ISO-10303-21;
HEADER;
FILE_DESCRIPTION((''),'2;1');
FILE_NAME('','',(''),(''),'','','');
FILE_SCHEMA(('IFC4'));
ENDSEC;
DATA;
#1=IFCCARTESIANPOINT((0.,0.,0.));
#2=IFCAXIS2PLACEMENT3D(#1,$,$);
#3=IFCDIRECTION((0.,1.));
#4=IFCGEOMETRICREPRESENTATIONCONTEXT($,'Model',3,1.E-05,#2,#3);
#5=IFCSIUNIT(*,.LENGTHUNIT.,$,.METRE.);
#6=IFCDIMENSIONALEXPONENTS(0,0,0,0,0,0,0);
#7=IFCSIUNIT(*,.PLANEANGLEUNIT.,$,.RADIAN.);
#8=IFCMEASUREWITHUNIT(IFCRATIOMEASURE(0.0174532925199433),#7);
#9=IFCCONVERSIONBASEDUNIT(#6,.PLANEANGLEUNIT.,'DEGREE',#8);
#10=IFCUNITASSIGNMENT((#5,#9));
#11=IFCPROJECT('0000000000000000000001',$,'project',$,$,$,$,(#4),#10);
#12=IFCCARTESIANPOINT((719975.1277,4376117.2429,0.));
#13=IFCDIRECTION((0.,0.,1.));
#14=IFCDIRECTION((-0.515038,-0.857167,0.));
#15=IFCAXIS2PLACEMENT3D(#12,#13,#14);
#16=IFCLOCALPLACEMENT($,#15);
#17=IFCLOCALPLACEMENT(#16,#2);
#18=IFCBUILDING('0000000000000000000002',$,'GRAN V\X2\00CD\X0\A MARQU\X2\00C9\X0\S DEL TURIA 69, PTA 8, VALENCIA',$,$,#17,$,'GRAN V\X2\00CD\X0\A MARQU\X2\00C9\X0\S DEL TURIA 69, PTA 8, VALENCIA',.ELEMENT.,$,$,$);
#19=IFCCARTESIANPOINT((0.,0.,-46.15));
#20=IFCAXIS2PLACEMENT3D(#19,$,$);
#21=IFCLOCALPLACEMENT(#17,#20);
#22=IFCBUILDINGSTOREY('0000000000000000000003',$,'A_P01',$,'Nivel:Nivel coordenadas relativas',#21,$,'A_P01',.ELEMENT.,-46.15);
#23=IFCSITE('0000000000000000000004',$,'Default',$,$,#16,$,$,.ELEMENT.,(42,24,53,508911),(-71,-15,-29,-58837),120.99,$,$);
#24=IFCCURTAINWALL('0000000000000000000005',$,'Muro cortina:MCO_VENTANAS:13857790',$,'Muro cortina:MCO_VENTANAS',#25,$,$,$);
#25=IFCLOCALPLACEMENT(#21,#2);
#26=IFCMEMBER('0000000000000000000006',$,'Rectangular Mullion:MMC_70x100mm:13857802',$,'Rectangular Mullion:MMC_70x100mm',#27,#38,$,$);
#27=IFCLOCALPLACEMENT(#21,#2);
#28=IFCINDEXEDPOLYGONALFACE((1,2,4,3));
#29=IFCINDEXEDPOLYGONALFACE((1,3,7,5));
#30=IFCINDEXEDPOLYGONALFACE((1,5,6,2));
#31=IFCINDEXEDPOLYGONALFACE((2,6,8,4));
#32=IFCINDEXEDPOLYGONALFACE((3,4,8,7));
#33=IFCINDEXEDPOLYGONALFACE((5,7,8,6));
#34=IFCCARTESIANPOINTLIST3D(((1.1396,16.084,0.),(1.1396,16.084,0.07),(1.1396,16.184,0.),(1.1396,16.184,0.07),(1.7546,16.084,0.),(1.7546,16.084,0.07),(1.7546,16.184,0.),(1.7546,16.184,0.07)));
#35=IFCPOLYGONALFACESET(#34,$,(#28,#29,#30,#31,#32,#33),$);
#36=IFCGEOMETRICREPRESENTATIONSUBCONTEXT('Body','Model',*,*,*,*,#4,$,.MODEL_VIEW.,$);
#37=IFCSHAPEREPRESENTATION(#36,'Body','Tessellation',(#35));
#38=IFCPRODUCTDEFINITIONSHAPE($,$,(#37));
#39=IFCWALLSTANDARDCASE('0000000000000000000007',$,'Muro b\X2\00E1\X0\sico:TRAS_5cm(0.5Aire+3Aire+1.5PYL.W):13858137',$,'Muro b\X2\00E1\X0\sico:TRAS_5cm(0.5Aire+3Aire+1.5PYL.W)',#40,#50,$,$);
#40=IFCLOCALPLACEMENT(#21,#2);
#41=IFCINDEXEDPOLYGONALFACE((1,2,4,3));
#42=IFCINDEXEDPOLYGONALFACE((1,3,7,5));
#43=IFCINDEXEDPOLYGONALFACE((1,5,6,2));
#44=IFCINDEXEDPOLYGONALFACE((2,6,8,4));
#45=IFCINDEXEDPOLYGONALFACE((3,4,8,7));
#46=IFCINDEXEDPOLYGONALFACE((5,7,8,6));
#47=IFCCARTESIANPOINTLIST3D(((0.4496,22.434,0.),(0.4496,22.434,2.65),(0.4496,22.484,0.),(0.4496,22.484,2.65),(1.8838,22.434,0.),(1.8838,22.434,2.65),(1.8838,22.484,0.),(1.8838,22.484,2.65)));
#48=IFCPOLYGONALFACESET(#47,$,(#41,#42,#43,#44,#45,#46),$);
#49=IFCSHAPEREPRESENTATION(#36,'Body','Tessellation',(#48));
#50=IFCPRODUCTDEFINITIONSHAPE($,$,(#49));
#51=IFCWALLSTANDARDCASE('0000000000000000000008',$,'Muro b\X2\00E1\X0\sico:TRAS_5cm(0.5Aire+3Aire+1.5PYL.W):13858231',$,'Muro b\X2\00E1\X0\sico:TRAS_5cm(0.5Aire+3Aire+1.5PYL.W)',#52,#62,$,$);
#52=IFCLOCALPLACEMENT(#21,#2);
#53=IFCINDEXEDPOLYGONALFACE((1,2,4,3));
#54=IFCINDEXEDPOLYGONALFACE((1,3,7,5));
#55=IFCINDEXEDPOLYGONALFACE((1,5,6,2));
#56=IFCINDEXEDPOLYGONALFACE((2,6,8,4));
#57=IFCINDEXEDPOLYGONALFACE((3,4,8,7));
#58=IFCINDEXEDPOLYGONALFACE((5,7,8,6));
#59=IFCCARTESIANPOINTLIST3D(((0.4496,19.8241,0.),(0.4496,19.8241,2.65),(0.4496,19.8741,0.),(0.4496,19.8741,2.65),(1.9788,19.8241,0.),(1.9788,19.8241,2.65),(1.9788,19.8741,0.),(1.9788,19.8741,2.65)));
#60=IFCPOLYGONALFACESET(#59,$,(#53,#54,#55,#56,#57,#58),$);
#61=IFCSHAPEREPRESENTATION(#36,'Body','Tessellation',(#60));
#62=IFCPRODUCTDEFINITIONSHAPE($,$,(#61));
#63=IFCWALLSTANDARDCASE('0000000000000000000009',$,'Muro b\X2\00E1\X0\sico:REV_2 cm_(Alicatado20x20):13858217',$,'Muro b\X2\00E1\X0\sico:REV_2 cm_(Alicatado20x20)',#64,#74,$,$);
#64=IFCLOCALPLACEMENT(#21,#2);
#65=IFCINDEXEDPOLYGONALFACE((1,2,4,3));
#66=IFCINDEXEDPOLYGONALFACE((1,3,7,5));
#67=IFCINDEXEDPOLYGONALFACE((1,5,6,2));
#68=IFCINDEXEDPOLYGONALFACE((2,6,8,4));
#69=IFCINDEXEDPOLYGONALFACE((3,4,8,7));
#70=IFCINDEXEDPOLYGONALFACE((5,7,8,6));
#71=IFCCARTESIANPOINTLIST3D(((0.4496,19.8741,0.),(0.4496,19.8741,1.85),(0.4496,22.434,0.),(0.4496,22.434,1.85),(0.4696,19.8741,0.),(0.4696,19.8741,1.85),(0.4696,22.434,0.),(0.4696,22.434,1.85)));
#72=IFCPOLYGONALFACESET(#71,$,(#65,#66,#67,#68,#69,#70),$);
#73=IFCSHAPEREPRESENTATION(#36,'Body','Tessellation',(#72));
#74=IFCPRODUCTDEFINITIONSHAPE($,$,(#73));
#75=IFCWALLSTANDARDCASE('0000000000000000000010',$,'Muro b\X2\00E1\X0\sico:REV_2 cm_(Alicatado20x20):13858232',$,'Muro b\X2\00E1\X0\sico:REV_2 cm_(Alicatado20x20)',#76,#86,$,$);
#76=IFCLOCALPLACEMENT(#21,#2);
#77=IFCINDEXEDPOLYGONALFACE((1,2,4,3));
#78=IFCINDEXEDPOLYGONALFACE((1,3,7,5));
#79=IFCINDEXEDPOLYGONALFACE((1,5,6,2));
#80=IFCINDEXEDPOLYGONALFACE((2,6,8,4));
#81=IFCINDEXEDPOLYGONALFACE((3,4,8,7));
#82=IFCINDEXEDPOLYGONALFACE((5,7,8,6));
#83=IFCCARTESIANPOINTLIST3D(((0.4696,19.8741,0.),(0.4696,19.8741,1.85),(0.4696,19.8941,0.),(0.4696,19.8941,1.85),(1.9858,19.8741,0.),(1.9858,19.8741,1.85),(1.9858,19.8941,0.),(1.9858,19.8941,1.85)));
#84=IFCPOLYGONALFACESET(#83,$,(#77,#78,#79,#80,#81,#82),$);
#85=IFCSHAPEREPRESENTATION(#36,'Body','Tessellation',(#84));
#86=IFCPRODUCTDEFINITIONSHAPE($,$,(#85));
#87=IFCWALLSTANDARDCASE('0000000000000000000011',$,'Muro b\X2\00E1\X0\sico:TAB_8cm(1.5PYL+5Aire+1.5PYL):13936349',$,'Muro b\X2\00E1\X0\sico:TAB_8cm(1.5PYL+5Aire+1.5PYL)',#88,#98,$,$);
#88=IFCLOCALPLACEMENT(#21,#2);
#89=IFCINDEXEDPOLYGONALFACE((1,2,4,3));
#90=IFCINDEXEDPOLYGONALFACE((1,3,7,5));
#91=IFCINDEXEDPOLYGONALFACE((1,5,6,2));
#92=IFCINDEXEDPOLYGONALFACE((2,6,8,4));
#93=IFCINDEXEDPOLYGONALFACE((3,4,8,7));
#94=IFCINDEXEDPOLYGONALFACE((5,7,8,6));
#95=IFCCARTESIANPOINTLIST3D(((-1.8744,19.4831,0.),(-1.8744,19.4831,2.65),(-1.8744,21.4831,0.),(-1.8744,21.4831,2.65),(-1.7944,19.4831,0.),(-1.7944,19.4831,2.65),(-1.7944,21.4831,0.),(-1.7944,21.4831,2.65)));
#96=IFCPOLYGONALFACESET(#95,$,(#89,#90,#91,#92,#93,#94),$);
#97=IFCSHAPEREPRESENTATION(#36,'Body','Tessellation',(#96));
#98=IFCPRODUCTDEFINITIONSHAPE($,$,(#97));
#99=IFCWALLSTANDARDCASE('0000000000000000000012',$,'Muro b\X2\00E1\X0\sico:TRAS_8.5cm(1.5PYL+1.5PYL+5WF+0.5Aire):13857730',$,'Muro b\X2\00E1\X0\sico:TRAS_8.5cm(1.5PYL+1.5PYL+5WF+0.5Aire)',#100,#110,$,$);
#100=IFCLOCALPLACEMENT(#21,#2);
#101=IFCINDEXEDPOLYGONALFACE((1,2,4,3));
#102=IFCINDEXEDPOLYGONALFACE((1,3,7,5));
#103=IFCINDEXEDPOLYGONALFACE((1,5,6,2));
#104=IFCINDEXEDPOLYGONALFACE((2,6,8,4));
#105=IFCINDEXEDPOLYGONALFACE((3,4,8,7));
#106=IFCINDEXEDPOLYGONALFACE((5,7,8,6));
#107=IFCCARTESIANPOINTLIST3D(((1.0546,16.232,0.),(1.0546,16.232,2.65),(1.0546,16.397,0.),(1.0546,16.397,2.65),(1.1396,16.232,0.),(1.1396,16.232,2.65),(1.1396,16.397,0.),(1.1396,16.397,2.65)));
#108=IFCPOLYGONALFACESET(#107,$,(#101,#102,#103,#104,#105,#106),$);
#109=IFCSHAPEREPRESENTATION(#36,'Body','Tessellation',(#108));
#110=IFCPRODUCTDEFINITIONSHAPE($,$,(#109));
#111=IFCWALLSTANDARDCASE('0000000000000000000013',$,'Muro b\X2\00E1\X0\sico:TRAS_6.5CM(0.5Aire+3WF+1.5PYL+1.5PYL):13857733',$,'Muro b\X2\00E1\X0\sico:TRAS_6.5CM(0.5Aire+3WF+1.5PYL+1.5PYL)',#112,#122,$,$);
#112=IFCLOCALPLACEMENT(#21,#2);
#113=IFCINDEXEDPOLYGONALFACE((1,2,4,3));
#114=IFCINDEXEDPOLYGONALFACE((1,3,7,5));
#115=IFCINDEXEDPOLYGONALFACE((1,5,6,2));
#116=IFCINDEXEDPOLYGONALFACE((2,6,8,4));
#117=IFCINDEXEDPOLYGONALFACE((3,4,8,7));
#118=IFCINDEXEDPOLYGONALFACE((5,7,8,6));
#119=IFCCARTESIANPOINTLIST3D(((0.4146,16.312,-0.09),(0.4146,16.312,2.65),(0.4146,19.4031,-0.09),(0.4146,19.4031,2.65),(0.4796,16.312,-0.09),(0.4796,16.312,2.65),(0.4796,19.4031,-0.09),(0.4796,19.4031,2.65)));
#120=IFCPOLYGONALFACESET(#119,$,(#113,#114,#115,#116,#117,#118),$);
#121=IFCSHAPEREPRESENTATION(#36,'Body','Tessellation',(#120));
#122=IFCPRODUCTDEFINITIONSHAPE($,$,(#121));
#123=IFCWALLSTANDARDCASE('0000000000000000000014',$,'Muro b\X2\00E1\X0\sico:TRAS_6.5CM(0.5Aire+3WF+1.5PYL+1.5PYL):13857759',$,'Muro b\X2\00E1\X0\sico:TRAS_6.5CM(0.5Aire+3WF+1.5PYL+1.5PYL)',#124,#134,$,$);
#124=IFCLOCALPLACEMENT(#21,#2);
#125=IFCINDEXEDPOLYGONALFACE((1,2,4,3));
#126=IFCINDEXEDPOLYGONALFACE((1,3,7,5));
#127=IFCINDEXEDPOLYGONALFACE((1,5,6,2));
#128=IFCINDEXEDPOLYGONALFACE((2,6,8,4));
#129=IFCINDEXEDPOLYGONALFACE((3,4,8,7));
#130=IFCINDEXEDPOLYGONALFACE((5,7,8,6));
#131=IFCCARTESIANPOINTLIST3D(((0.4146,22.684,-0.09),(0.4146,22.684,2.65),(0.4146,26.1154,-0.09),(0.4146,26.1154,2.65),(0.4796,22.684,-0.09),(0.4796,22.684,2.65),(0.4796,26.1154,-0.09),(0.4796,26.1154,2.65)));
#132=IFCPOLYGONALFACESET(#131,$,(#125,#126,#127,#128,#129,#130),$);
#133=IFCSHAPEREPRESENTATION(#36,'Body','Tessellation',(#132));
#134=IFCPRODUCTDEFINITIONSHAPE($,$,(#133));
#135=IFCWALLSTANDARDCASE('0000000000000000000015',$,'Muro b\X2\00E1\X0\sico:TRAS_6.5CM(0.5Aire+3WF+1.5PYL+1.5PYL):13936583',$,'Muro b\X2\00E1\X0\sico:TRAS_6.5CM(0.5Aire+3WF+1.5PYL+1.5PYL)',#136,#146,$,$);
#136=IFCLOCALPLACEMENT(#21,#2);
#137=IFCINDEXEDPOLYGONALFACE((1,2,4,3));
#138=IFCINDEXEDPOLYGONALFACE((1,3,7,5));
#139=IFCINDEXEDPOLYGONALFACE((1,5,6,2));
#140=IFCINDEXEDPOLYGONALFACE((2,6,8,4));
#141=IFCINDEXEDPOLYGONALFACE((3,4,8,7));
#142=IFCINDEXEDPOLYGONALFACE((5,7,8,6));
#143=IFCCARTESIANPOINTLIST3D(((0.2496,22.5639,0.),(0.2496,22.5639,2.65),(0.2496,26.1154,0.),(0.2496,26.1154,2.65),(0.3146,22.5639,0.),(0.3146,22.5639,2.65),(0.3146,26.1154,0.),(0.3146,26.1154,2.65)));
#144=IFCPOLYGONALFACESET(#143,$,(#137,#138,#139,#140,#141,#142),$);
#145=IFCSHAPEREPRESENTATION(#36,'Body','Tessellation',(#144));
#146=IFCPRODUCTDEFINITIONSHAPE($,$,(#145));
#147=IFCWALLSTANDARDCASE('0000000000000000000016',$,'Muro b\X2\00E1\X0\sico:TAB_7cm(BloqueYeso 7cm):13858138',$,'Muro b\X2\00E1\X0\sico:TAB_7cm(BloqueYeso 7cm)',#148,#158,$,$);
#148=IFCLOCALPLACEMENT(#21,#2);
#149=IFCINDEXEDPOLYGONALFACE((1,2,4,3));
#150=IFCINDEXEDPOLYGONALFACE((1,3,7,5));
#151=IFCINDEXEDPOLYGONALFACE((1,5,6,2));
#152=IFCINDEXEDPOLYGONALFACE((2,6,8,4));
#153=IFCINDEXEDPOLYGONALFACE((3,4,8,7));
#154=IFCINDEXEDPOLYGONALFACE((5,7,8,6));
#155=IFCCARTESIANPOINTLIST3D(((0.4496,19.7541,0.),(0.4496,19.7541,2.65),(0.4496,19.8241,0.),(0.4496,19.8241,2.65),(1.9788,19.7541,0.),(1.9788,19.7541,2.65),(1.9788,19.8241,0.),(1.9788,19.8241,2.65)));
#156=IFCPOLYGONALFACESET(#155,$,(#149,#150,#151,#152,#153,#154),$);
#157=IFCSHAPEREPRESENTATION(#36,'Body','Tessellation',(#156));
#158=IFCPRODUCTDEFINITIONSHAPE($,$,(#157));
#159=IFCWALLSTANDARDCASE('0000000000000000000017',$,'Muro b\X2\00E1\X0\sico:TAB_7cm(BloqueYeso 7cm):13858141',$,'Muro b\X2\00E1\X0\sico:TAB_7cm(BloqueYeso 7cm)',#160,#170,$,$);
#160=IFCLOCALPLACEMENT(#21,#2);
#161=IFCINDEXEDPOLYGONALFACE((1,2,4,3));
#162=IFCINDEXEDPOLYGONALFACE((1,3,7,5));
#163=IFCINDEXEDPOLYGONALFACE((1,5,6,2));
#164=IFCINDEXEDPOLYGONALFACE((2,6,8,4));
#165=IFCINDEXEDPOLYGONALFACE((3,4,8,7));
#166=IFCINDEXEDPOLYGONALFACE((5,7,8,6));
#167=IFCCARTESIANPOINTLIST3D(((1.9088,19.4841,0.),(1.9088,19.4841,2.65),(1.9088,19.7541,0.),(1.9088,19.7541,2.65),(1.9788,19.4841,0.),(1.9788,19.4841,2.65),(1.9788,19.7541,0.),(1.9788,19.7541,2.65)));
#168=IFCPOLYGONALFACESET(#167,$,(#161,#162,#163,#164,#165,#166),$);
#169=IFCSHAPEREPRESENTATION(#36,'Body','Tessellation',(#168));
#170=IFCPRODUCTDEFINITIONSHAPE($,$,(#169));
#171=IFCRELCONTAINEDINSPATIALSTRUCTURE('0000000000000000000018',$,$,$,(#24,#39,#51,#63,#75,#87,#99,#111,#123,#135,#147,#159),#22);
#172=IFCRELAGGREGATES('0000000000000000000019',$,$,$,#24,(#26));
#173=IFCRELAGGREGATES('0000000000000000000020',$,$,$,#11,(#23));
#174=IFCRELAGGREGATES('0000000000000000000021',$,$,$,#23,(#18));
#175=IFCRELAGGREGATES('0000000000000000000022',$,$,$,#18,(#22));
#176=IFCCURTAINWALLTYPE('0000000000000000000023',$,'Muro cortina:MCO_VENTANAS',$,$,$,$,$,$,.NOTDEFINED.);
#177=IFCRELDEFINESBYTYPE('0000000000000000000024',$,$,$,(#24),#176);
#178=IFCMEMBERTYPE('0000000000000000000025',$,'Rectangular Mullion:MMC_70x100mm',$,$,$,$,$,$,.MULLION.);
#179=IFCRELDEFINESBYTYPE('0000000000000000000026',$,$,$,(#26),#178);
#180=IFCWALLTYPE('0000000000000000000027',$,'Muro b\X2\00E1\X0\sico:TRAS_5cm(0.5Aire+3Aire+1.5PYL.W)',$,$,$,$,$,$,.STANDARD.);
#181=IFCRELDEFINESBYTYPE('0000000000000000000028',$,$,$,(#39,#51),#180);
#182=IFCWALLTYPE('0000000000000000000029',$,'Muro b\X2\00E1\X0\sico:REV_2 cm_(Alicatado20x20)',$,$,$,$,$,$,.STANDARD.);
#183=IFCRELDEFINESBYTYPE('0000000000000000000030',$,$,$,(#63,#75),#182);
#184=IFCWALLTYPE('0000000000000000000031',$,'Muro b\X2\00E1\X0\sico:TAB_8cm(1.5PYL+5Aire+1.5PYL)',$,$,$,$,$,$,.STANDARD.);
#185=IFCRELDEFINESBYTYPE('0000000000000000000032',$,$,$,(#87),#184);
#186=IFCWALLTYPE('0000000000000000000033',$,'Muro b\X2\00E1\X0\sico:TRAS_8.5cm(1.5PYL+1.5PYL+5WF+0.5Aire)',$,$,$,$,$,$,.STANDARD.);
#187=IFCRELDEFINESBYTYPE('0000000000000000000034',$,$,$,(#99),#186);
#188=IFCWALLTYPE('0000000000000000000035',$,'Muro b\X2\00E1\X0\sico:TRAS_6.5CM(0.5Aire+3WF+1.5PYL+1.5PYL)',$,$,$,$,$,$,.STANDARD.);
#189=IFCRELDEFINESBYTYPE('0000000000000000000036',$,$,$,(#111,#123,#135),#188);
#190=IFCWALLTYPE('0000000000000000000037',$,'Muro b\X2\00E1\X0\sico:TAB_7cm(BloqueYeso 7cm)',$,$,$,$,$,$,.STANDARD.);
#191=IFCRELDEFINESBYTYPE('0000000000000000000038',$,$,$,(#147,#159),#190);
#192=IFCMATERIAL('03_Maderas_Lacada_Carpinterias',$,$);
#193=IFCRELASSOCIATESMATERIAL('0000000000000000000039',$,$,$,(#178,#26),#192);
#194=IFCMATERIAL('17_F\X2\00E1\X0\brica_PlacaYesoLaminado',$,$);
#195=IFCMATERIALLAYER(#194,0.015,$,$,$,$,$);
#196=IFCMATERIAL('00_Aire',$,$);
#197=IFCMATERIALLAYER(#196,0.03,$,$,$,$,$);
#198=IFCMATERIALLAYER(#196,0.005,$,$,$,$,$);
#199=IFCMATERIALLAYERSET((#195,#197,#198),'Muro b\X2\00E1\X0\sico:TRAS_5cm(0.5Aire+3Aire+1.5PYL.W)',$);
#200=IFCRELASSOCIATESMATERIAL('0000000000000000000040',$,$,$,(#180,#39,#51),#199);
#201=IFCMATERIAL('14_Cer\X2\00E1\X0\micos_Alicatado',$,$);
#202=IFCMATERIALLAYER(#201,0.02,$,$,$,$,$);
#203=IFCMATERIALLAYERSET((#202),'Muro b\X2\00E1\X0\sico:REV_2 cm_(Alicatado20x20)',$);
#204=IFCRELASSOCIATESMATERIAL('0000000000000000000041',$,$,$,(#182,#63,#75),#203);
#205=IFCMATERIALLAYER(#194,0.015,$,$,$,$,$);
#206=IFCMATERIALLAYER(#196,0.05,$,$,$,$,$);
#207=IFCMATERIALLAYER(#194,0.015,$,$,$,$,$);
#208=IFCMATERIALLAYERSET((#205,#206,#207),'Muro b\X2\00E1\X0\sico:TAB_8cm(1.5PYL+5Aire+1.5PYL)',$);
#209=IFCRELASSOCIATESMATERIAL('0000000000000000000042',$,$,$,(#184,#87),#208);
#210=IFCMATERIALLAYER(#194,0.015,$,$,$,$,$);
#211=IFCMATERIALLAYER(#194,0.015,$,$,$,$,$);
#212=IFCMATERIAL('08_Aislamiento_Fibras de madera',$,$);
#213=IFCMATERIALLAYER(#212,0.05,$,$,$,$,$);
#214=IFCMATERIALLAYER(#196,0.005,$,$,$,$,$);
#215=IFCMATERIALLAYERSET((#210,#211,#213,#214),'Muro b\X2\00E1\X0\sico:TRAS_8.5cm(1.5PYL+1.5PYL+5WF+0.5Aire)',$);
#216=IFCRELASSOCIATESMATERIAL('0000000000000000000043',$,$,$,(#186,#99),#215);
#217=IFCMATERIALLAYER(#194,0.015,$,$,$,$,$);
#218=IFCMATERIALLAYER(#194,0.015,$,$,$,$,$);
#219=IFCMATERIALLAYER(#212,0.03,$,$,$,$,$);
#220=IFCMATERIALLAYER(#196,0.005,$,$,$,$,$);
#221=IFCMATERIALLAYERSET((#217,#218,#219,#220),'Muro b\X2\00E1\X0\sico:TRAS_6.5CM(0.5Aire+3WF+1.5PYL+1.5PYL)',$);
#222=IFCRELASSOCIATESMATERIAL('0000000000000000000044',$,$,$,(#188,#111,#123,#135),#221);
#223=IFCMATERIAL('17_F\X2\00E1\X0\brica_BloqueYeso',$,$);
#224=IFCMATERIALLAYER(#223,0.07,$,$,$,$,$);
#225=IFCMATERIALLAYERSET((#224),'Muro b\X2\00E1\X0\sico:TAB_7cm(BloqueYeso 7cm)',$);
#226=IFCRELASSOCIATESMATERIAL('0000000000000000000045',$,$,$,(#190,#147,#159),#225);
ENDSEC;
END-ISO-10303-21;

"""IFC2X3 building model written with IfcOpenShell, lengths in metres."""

from ifc_helpers import new_model, entity, si_unit, converted_unit, direction, frame, frame_2d, origin, origin_2d_with_axis, place, context, subcontext, project, spatial, rectangle, extrude, source, transform, mapped, material, layer, layer_set, layer_usage, type_object, type_shapes, element, aggregate, save


model = new_model("IFC2X3")

# Units and contexts
model_context = context("Model", 3, precision=1e-05, world=origin(), true_north=direction((0.0, 1.0)))
body_context = subcontext(model_context, "Body", "Model", "MODEL_VIEW")
ifc_project = project(units=[si_unit("LENGTHUNIT", "METRE"), converted_unit("PLANEANGLEUNIT", "DEGREE", entity("IfcRatioMeasure", 0.0174532925199433), si_unit("PLANEANGLEUNIT", "RADIAN"), dimensions=[0, 0, 0, 0, 0, 0, 0])], contexts=[model_context])

# Site, building, storey
site_placement = place(None, frame((719975.1277, 4376117.2429, 0.0), z_axis=(0.0, 0.0, 1.0), x_axis=(-0.515038, -0.857167, 0.0)))
site = spatial("IfcSite", under=ifc_project, at=site_placement, Name="Default", CompositionType="ELEMENT", RefLatitude=(42, 24, 53, 508911), RefLongitude=(-71, -15, -29, -58837), RefElevation=120.99)
building_placement = place(site_placement, origin())
building = spatial("IfcBuilding", under=site, at=building_placement, Name="GRAN VÍA MARQUÉS DEL TURIA 69, PTA 8, VALENCIA", LongName="GRAN VÍA MARQUÉS DEL TURIA 69, PTA 8, VALENCIA", CompositionType="ELEMENT")
storey_placement = place(building_placement, frame((0.0, 0.0, -46.15)))
storey = spatial("IfcBuildingStorey", under=building, at=storey_placement, Name="A_P01", ObjectType="Nivel:Nivel coordenadas relativas", LongName="A_P01", CompositionType="ELEMENT", Elevation=-46.15)

# Curtain wall, member
curtain_wall_type = type_object("IfcCurtainWallType", Name="Muro cortina:MCO_VENTANAS", PredefinedType="NOTDEFINED")
curtain_wall_placement = place(storey_placement, frame((0.0, 0.0, 46.15)))
curtain_wall = element("IfcCurtainWall", 1, at=curtain_wall_placement, inside=storey, type_object=curtain_wall_type, Name="Muro cortina:MCO_VENTANAS:13857790", ObjectType="Muro cortina:MCO_VENTANAS")
ifc_material_1 = material(Name="03_Maderas_Lacada_Carpinterias")
member_type = type_object("IfcMemberType", Name="Rectangular Mullion:MMC_70x100mm", PredefinedType="MULLION", material=ifc_material_1)
shared_shape_1 = source(origin(), body_context, "Body", "SweptSolid", [
    extrude(rectangle(XDim=0.1, YDim=0.07, at=origin_2d_with_axis()), frame((-0.035, 0.0, -0.615), z_axis=(0.0, 0.0, 1.0), x_axis=(0.0, -1.0, 0.0)), (0.0, 0.0, 1.0), 0.615),
])
type_shapes(member_type, [shared_shape_1])
member_placement = place(storey_placement, frame((1.1396, 16.134, 0.0), z_axis=(-1.0, 0.0, 0.0), x_axis=(0.0, 0.0, -1.0)))
member = element("IfcMember", 2, at=member_placement, type_object=member_type, material=ifc_material_1, Name="Rectangular Mullion:MMC_70x100mm:13857802", ObjectType="Rectangular Mullion:MMC_70x100mm", context=body_context, shape_type="MappedRepresentation", body=[
    mapped(shared_shape_1, transform((0.0, 0.0, 0.0), scale=1.0)),
])
aggregate(curtain_wall, [member])

# Walls
ifc_material_2 = material(Name="17_Fábrica_PlacaYesoLaminado")
ifc_layer_1 = layer(ifc_material_2, 0.015)
ifc_material_3 = material(Name="00_Aire")
ifc_layer_2 = layer(ifc_material_3, 0.03)
ifc_layer_3 = layer(ifc_material_3, 0.005)
ifc_layer_set_1 = layer_set([ifc_layer_1, ifc_layer_2, ifc_layer_3], Name="Muro básico:TRAS_5cm(0.5Aire+3Aire+1.5PYL.W)")
ifc_layer_usage_1 = layer_usage(ifc_layer_set_1, "AXIS2", "POSITIVE", -0.025)
wall_type_1 = type_object("IfcWallType", Name="Muro básico:TRAS_5cm(0.5Aire+3Aire+1.5PYL.W)", PredefinedType="STANDARD", material=ifc_layer_set_1)
wall_1_placement = place(storey_placement, frame((0.4496, 22.459, 0.0)))
element("IfcWallStandardCase", 3, at=wall_1_placement, inside=storey, type_object=wall_type_1, material=ifc_layer_usage_1, Name="Muro básico:TRAS_5cm(0.5Aire+3Aire+1.5PYL.W):13858137", ObjectType="Muro básico:TRAS_5cm(0.5Aire+3Aire+1.5PYL.W)", context=body_context, shape_type="SweptSolid", body=[
    extrude(rectangle(XDim=1.4342, YDim=0.05, at=frame_2d((0.7171, 0.0), x_axis=(-1.0, 0.0))), origin(), (0.0, 0.0, 1.0), 2.65),
])
ifc_layer_usage_2 = layer_usage(ifc_layer_set_1, "AXIS2", "NEGATIVE", 0.025)
wall_2_placement = place(storey_placement, frame((0.4496, 19.8491, 0.0)))
element("IfcWallStandardCase", 4, at=wall_2_placement, inside=storey, type_object=wall_type_1, material=ifc_layer_usage_2, Name="Muro básico:TRAS_5cm(0.5Aire+3Aire+1.5PYL.W):13858231", ObjectType="Muro básico:TRAS_5cm(0.5Aire+3Aire+1.5PYL.W)", context=body_context, shape_type="SweptSolid", body=[
    extrude(rectangle(XDim=1.5292, YDim=0.05, at=frame_2d((0.7646, 0.0), x_axis=(-1.0, 0.0))), origin(), (0.0, 0.0, 1.0), 2.65),
])
ifc_material_4 = material(Name="14_Cerámicos_Alicatado")
ifc_layer_4 = layer(ifc_material_4, 0.02)
ifc_layer_set_2 = layer_set([ifc_layer_4], Name="Muro básico:REV_2 cm_(Alicatado20x20)")
ifc_layer_usage_3 = layer_usage(ifc_layer_set_2, "AXIS2", "NEGATIVE", 0.01)
wall_type_2 = type_object("IfcWallType", Name="Muro básico:REV_2 cm_(Alicatado20x20)", PredefinedType="STANDARD", material=ifc_layer_set_2)
wall_3_placement = place(storey_placement, frame((0.4596, 22.434, 0.0), z_axis=(0.0, 0.0, 1.0), x_axis=(0.0, -1.0, 0.0)))
element("IfcWallStandardCase", 5, at=wall_3_placement, inside=storey, type_object=wall_type_2, material=ifc_layer_usage_3, Name="Muro básico:REV_2 cm_(Alicatado20x20):13858217", ObjectType="Muro básico:REV_2 cm_(Alicatado20x20)", context=body_context, shape_type="SweptSolid", body=[
    extrude(rectangle(XDim=2.56, YDim=0.02, at=frame_2d((1.28, 0.0), x_axis=(-1.0, 0.0))), origin(), (0.0, 0.0, 1.0), 1.85),
])
ifc_layer_usage_4 = layer_usage(ifc_layer_set_2, "AXIS2", "POSITIVE", -0.01)
wall_4_placement = place(storey_placement, frame((1.9858, 19.8841, 0.0), z_axis=(0.0, 0.0, 1.0), x_axis=(-1.0, 0.0, 0.0)))
element("IfcWallStandardCase", 6, at=wall_4_placement, inside=storey, type_object=wall_type_2, material=ifc_layer_usage_4, Name="Muro básico:REV_2 cm_(Alicatado20x20):13858232", ObjectType="Muro básico:REV_2 cm_(Alicatado20x20)", context=body_context, shape_type="SweptSolid", body=[
    extrude(rectangle(XDim=1.5162, YDim=0.02, at=frame_2d((0.7581, 0.0), x_axis=(-1.0, 0.0))), origin(), (0.0, 0.0, 1.0), 1.85),
])
ifc_layer_5 = layer(ifc_material_2, 0.015)
ifc_layer_6 = layer(ifc_material_3, 0.05)
ifc_layer_7 = layer(ifc_material_2, 0.015)
ifc_layer_set_3 = layer_set([ifc_layer_5, ifc_layer_6, ifc_layer_7], Name="Muro básico:TAB_8cm(1.5PYL+5Aire+1.5PYL)")
ifc_layer_usage_5 = layer_usage(ifc_layer_set_3, "AXIS2", "NEGATIVE", 0.04)
wall_type_3 = type_object("IfcWallType", Name="Muro básico:TAB_8cm(1.5PYL+5Aire+1.5PYL)", PredefinedType="STANDARD", material=ifc_layer_set_3)
wall_5_placement = place(storey_placement, frame((-1.8344, 21.4831, 0.0), z_axis=(0.0, 0.0, 1.0), x_axis=(0.0, -1.0, 0.0)))
element("IfcWallStandardCase", 7, at=wall_5_placement, inside=storey, type_object=wall_type_3, material=ifc_layer_usage_5, Name="Muro básico:TAB_8cm(1.5PYL+5Aire+1.5PYL):13936349", ObjectType="Muro básico:TAB_8cm(1.5PYL+5Aire+1.5PYL)", context=body_context, shape_type="SweptSolid", body=[
    extrude(rectangle(XDim=2.0, YDim=0.08, at=frame_2d((1.0, 0.0), x_axis=(-1.0, 0.0))), origin(), (0.0, 0.0, 1.0), 2.65),
])
ifc_layer_8 = layer(ifc_material_2, 0.015)
ifc_layer_9 = layer(ifc_material_2, 0.015)
ifc_material_5 = material(Name="08_Aislamiento_Fibras de madera")
ifc_layer_10 = layer(ifc_material_5, 0.05)
ifc_layer_11 = layer(ifc_material_3, 0.005)
ifc_layer_set_4 = layer_set([ifc_layer_8, ifc_layer_9, ifc_layer_10, ifc_layer_11], Name="Muro básico:TRAS_8.5cm(1.5PYL+1.5PYL+5WF+0.5Aire)")
ifc_layer_usage_6 = layer_usage(ifc_layer_set_4, "AXIS2", "NEGATIVE", 0.0425)
wall_type_4 = type_object("IfcWallType", Name="Muro básico:TRAS_8.5cm(1.5PYL+1.5PYL+5WF+0.5Aire)", PredefinedType="STANDARD", material=ifc_layer_set_4)
wall_6_placement = place(storey_placement, frame((1.0971, 16.397, 0.0), z_axis=(0.0, 0.0, 1.0), x_axis=(0.0, -1.0, 0.0)))
element("IfcWallStandardCase", 8, at=wall_6_placement, inside=storey, type_object=wall_type_4, material=ifc_layer_usage_6, Name="Muro básico:TRAS_8.5cm(1.5PYL+1.5PYL+5WF+0.5Aire):13857730", ObjectType="Muro básico:TRAS_8.5cm(1.5PYL+1.5PYL+5WF+0.5Aire)", context=body_context, shape_type="SweptSolid", body=[
    extrude(rectangle(XDim=0.165, YDim=0.085, at=frame_2d((0.0825, 0.0), x_axis=(-1.0, 0.0))), origin(), (0.0, 0.0, 1.0), 2.65),
])
ifc_layer_12 = layer(ifc_material_2, 0.015)
ifc_layer_13 = layer(ifc_material_2, 0.015)
ifc_layer_14 = layer(ifc_material_5, 0.03)
ifc_layer_15 = layer(ifc_material_3, 0.005)
ifc_layer_set_5 = layer_set([ifc_layer_12, ifc_layer_13, ifc_layer_14, ifc_layer_15], Name="Muro básico:TRAS_6.5CM(0.5Aire+3WF+1.5PYL+1.5PYL)")
ifc_layer_usage_7 = layer_usage(ifc_layer_set_5, "AXIS2", "NEGATIVE", 0.0325)
wall_type_5 = type_object("IfcWallType", Name="Muro básico:TRAS_6.5CM(0.5Aire+3WF+1.5PYL+1.5PYL)", PredefinedType="STANDARD", material=ifc_layer_set_5)
wall_7_placement = place(storey_placement, frame((0.4471, 19.4031, -0.09), z_axis=(0.0, 0.0, 1.0), x_axis=(0.0, -1.0, 0.0)))
element("IfcWallStandardCase", 9, at=wall_7_placement, inside=storey, type_object=wall_type_5, material=ifc_layer_usage_7, Name="Muro básico:TRAS_6.5CM(0.5Aire+3WF+1.5PYL+1.5PYL):13857733", ObjectType="Muro básico:TRAS_6.5CM(0.5Aire+3WF+1.5PYL+1.5PYL)", context=body_context, shape_type="SweptSolid", body=[
    extrude(rectangle(XDim=3.091, YDim=0.065, at=frame_2d((1.5455, 0.0), x_axis=(-1.0, 0.0))), origin(), (0.0, 0.0, 1.0), 2.74),
])
ifc_layer_usage_8 = layer_usage(ifc_layer_set_5, "AXIS2", "POSITIVE", -0.0325)
wall_8_placement = place(storey_placement, frame((0.4471, 22.684, -0.09), z_axis=(0.0, 0.0, 1.0), x_axis=(0.0, 1.0, 0.0)))
element("IfcWallStandardCase", 10, at=wall_8_placement, inside=storey, type_object=wall_type_5, material=ifc_layer_usage_8, Name="Muro básico:TRAS_6.5CM(0.5Aire+3WF+1.5PYL+1.5PYL):13857759", ObjectType="Muro básico:TRAS_6.5CM(0.5Aire+3WF+1.5PYL+1.5PYL)", context=body_context, shape_type="SweptSolid", body=[
    extrude(rectangle(XDim=3.4313, YDim=0.065, at=frame_2d((1.7157, 0.0), x_axis=(-1.0, 0.0))), origin(), (0.0, 0.0, 1.0), 2.74),
])
ifc_layer_usage_9 = layer_usage(ifc_layer_set_5, "AXIS2", "NEGATIVE", 0.0325)
wall_9_placement = place(storey_placement, frame((0.2821, 22.5639, 0.0), z_axis=(0.0, 0.0, 1.0), x_axis=(0.0, 1.0, 0.0)))
element("IfcWallStandardCase", 11, at=wall_9_placement, inside=storey, type_object=wall_type_5, material=ifc_layer_usage_9, Name="Muro básico:TRAS_6.5CM(0.5Aire+3WF+1.5PYL+1.5PYL):13936583", ObjectType="Muro básico:TRAS_6.5CM(0.5Aire+3WF+1.5PYL+1.5PYL)", context=body_context, shape_type="SweptSolid", body=[
    extrude(rectangle(XDim=3.5515, YDim=0.065, at=frame_2d((1.7757, 0.0), x_axis=(-1.0, 0.0))), origin(), (0.0, 0.0, 1.0), 2.65),
])
ifc_material_6 = material(Name="17_Fábrica_BloqueYeso")
ifc_layer_16 = layer(ifc_material_6, 0.07)
ifc_layer_set_6 = layer_set([ifc_layer_16], Name="Muro básico:TAB_7cm(BloqueYeso 7cm)")
ifc_layer_usage_10 = layer_usage(ifc_layer_set_6, "AXIS2", "NEGATIVE", 0.035)
wall_type_6 = type_object("IfcWallType", Name="Muro básico:TAB_7cm(BloqueYeso 7cm)", PredefinedType="STANDARD", material=ifc_layer_set_6)
wall_10_placement = place(storey_placement, frame((0.4496, 19.7891, 0.0)))
element("IfcWallStandardCase", 12, at=wall_10_placement, inside=storey, type_object=wall_type_6, material=ifc_layer_usage_10, Name="Muro básico:TAB_7cm(BloqueYeso 7cm):13858138", ObjectType="Muro básico:TAB_7cm(BloqueYeso 7cm)", context=body_context, shape_type="SweptSolid", body=[
    extrude(rectangle(XDim=1.5292, YDim=0.07, at=frame_2d((0.7646, 0.0), x_axis=(-1.0, 0.0))), origin(), (0.0, 0.0, 1.0), 2.65),
])
ifc_layer_usage_11 = layer_usage(ifc_layer_set_6, "AXIS2", "POSITIVE", -0.035)
wall_11_placement = place(storey_placement, frame((1.9438, 19.4841, 0.0), z_axis=(0.0, 0.0, 1.0), x_axis=(0.0, 1.0, 0.0)))
element("IfcWallStandardCase", 13, at=wall_11_placement, inside=storey, type_object=wall_type_6, material=ifc_layer_usage_11, Name="Muro básico:TAB_7cm(BloqueYeso 7cm):13858141", ObjectType="Muro básico:TAB_7cm(BloqueYeso 7cm)", context=body_context, shape_type="SweptSolid", body=[
    extrude(rectangle(XDim=0.27, YDim=0.07, at=frame_2d((0.135, 0.0), x_axis=(-1.0, 0.0))), origin(), (0.0, 0.0, 1.0), 2.65),
])

save(model, "model.ifc")
